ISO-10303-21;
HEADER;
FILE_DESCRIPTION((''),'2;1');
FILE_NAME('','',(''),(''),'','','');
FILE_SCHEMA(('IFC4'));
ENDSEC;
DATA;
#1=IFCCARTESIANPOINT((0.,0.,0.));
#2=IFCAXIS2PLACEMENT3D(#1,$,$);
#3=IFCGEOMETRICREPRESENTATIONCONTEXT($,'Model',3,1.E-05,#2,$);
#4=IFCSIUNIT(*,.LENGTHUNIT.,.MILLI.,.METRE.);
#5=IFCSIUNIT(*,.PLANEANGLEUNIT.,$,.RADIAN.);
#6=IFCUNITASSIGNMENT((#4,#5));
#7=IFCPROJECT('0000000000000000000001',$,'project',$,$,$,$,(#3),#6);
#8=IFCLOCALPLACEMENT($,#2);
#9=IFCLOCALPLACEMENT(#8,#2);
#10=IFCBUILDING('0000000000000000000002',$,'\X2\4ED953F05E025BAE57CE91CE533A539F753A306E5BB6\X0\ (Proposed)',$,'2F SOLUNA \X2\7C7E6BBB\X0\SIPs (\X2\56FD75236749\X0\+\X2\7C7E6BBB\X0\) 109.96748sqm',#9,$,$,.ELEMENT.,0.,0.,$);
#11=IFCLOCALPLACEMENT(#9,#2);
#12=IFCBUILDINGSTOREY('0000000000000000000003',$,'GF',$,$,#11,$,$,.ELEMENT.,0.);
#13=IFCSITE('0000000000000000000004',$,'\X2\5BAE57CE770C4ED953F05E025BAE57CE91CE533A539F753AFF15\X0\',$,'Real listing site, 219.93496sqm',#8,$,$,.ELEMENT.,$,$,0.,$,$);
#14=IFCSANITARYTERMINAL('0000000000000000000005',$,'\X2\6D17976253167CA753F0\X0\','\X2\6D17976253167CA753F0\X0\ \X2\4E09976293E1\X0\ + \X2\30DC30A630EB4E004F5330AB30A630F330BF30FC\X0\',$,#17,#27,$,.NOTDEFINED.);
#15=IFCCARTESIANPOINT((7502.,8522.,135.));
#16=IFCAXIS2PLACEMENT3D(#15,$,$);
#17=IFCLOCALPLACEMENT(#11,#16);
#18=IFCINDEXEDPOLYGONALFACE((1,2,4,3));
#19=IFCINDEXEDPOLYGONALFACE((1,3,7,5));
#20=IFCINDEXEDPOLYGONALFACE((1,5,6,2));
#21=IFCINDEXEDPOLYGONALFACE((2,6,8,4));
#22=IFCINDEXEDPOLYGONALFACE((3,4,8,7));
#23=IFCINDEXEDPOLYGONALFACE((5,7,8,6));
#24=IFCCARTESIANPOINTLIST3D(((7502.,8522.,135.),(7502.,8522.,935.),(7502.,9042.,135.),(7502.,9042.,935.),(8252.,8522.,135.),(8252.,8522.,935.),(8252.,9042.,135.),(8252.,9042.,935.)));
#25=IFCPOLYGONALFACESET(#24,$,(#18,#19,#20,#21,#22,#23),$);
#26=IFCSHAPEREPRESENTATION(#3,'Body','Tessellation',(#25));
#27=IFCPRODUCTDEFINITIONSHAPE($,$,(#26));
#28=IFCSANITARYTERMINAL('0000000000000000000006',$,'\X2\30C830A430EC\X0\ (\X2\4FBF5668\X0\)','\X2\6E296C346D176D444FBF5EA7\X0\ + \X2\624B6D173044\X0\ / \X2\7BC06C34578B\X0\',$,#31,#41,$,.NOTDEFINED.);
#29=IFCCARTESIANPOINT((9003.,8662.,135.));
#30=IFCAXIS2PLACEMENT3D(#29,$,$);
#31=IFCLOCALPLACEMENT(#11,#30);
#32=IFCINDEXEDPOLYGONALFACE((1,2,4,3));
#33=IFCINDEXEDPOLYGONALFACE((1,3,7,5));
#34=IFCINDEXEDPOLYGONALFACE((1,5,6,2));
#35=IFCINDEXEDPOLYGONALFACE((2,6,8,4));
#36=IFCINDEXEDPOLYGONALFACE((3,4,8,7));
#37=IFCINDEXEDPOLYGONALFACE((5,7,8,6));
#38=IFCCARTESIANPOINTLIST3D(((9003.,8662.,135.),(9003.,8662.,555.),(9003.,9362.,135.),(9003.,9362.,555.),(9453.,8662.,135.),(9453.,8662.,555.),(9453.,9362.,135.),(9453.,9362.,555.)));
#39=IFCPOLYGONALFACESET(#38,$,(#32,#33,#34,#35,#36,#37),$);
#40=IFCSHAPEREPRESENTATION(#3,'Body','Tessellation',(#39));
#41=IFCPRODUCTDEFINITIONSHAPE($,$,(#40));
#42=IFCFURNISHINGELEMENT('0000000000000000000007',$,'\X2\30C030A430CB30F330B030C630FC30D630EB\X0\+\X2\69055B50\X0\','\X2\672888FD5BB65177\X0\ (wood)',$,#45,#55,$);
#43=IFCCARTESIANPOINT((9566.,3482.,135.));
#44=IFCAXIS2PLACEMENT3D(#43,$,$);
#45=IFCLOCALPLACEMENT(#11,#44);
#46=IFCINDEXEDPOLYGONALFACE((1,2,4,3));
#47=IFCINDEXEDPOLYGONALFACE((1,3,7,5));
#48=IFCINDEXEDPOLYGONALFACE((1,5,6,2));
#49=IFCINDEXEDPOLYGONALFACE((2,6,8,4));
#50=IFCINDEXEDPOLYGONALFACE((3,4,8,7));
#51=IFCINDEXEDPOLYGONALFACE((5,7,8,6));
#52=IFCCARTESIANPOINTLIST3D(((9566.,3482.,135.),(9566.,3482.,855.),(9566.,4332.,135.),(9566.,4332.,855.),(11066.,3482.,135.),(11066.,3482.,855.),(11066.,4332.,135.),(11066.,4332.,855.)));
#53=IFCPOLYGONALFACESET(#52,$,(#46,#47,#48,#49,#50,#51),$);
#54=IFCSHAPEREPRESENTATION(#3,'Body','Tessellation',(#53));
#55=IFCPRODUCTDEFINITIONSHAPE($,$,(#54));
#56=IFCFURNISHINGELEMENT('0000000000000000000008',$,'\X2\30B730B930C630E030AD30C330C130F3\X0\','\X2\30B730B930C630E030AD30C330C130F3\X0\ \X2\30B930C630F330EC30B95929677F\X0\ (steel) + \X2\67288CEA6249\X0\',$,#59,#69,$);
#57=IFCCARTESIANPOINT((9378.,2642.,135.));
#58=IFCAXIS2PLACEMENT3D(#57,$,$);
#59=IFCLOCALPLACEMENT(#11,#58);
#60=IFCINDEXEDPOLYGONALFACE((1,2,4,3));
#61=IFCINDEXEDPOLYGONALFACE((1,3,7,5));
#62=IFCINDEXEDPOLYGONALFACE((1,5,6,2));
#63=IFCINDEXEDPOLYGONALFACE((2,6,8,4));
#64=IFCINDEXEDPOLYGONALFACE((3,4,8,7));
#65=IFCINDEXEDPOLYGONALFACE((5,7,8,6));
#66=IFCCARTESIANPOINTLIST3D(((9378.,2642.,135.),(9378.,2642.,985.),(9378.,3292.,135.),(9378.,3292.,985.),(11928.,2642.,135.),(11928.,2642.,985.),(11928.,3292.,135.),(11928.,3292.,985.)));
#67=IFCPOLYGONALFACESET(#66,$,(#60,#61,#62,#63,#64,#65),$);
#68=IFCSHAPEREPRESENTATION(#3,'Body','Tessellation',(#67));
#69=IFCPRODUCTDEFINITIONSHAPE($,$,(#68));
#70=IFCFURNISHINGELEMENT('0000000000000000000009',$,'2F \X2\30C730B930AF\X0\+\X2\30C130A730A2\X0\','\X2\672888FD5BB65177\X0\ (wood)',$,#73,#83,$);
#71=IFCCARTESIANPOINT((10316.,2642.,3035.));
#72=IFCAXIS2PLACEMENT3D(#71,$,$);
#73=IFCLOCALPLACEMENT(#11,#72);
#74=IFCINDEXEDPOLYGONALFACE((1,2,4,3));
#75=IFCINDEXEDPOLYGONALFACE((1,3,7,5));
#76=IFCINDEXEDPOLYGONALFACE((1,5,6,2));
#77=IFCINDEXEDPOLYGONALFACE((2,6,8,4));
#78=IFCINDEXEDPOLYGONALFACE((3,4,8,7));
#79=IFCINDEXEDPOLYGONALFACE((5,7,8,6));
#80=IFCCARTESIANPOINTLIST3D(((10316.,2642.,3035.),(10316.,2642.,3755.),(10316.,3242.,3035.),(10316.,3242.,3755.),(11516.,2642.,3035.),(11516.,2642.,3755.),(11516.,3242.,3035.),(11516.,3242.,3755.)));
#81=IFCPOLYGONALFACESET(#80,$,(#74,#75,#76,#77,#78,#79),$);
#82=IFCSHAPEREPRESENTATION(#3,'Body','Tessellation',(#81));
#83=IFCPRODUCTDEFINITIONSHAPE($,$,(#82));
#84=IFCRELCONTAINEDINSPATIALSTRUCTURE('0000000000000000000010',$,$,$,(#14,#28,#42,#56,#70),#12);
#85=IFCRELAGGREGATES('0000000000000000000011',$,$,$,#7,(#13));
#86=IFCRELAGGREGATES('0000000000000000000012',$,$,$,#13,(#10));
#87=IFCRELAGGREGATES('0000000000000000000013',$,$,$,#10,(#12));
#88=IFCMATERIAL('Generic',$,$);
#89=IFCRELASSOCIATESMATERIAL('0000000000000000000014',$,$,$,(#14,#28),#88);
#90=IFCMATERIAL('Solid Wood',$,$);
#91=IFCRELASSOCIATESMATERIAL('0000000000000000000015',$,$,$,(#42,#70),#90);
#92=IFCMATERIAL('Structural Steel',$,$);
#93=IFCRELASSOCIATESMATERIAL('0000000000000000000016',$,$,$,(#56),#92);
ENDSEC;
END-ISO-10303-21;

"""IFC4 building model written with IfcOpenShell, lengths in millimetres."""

from ifc_helpers import new_model, si_unit, frame, frame_2d, origin, place, context, project, spatial, rectangle, extrude, material, element, save


model = new_model("IFC4")

# Units and contexts
model_context = context("Model", 3, precision=1e-05, world=origin())
ifc_project = project(units=[si_unit("LENGTHUNIT", "METRE", prefix="MILLI"), si_unit("PLANEANGLEUNIT", "RADIAN")], contexts=[model_context])

# Site, building, storey
site_placement = place(None, origin())
site = spatial("IfcSite", under=ifc_project, at=site_placement, Name="宮城県仙台市宮城野区原町５", ObjectType="Real listing site, 219.93496sqm", CompositionType="ELEMENT", RefElevation=0.0)
building_placement = place(site_placement, origin())
building = spatial("IfcBuilding", under=site, at=building_placement, Name="仙台市宮城野区原町の家 (Proposed)", ObjectType="2F SOLUNA 籾殻SIPs (国産杉+籾殻) 109.96748sqm", CompositionType="ELEMENT", ElevationOfRefHeight=0.0, ElevationOfTerrain=0.0)
storey_placement = place(building_placement, origin())
storey = spatial("IfcBuildingStorey", under=building, at=storey_placement, Name="GF", CompositionType="ELEMENT", Elevation=0.0)

# Shared definitions
ifc_material_1 = material(Name="Solid Wood")

# Sanitary terminals
ifc_material_2 = material(Name="Generic")
sanitary_terminal_1_placement = place(storey_placement, frame((7502.0, 8522.0, 135.0)))
element("IfcSanitaryTerminal", 1, at=sanitary_terminal_1_placement, inside=storey, material=ifc_material_2, Name="洗面化粧台", Description="洗面化粧台 三面鏡 + ボウル一体カウンター", PredefinedType="NOTDEFINED", context=model_context, shape_type="SweptSolid", body=[
    extrude(rectangle(XDim=750.0, YDim=520.0, at=frame_2d((375.0, 260.0))), frame((7502.0, 8522.0, 135.0)), (0.0, 0.0, 1.0), 800.0),
])
sanitary_terminal_2_placement = place(storey_placement, frame((9003.0, 8662.0, 135.0)))
element("IfcSanitaryTerminal", 2, at=sanitary_terminal_2_placement, inside=storey, material=ifc_material_2, Name="トイレ (便器)", Description="温水洗浄便座 + 手洗い / 節水型", PredefinedType="NOTDEFINED", context=model_context, shape_type="SweptSolid", body=[
    extrude(rectangle(XDim=450.0, YDim=700.0, at=frame_2d((225.0, 350.0))), frame((9003.0, 8662.0, 135.0)), (0.0, 0.0, 1.0), 420.0),
])

# Furnishing elements
furnishing_1_placement = place(storey_placement, frame((9566.0, 3482.0, 135.0)))
element("IfcFurnishingElement", 3, at=furnishing_1_placement, inside=storey, material=ifc_material_1, Name="ダイニングテーブル+椅子", Description="木製家具 (wood)", context=model_context, shape_type="SweptSolid", body=[
    extrude(rectangle(XDim=1500.0, YDim=850.0, at=frame_2d((750.0, 425.0))), frame((9566.0, 3482.0, 135.0)), (0.0, 0.0, 1.0), 720.0),
])
ifc_material_3 = material(Name="Structural Steel")
furnishing_2_placement = place(storey_placement, frame((9378.0, 2642.0, 135.0)))
element("IfcFurnishingElement", 4, at=furnishing_2_placement, inside=storey, material=ifc_material_3, Name="システムキッチン", Description="システムキッチン ステンレス天板 (steel) + 木質扉", context=model_context, shape_type="SweptSolid", body=[
    extrude(rectangle(XDim=2550.0, YDim=650.0, at=frame_2d((1275.0, 325.0))), frame((9378.0, 2642.0, 135.0)), (0.0, 0.0, 1.0), 850.0),
])
furnishing_3_placement = place(storey_placement, frame((10316.0, 2642.0, 3035.0)))
element("IfcFurnishingElement", 5, at=furnishing_3_placement, inside=storey, material=ifc_material_1, Name="2F デスク+チェア", Description="木製家具 (wood)", context=model_context, shape_type="SweptSolid", body=[
    extrude(rectangle(XDim=1200.0, YDim=600.0, at=frame_2d((600.0, 300.0))), frame((10316.0, 2642.0, 3035.0)), (0.0, 0.0, 1.0), 720.0),
])

save(model, "model.ifc")
